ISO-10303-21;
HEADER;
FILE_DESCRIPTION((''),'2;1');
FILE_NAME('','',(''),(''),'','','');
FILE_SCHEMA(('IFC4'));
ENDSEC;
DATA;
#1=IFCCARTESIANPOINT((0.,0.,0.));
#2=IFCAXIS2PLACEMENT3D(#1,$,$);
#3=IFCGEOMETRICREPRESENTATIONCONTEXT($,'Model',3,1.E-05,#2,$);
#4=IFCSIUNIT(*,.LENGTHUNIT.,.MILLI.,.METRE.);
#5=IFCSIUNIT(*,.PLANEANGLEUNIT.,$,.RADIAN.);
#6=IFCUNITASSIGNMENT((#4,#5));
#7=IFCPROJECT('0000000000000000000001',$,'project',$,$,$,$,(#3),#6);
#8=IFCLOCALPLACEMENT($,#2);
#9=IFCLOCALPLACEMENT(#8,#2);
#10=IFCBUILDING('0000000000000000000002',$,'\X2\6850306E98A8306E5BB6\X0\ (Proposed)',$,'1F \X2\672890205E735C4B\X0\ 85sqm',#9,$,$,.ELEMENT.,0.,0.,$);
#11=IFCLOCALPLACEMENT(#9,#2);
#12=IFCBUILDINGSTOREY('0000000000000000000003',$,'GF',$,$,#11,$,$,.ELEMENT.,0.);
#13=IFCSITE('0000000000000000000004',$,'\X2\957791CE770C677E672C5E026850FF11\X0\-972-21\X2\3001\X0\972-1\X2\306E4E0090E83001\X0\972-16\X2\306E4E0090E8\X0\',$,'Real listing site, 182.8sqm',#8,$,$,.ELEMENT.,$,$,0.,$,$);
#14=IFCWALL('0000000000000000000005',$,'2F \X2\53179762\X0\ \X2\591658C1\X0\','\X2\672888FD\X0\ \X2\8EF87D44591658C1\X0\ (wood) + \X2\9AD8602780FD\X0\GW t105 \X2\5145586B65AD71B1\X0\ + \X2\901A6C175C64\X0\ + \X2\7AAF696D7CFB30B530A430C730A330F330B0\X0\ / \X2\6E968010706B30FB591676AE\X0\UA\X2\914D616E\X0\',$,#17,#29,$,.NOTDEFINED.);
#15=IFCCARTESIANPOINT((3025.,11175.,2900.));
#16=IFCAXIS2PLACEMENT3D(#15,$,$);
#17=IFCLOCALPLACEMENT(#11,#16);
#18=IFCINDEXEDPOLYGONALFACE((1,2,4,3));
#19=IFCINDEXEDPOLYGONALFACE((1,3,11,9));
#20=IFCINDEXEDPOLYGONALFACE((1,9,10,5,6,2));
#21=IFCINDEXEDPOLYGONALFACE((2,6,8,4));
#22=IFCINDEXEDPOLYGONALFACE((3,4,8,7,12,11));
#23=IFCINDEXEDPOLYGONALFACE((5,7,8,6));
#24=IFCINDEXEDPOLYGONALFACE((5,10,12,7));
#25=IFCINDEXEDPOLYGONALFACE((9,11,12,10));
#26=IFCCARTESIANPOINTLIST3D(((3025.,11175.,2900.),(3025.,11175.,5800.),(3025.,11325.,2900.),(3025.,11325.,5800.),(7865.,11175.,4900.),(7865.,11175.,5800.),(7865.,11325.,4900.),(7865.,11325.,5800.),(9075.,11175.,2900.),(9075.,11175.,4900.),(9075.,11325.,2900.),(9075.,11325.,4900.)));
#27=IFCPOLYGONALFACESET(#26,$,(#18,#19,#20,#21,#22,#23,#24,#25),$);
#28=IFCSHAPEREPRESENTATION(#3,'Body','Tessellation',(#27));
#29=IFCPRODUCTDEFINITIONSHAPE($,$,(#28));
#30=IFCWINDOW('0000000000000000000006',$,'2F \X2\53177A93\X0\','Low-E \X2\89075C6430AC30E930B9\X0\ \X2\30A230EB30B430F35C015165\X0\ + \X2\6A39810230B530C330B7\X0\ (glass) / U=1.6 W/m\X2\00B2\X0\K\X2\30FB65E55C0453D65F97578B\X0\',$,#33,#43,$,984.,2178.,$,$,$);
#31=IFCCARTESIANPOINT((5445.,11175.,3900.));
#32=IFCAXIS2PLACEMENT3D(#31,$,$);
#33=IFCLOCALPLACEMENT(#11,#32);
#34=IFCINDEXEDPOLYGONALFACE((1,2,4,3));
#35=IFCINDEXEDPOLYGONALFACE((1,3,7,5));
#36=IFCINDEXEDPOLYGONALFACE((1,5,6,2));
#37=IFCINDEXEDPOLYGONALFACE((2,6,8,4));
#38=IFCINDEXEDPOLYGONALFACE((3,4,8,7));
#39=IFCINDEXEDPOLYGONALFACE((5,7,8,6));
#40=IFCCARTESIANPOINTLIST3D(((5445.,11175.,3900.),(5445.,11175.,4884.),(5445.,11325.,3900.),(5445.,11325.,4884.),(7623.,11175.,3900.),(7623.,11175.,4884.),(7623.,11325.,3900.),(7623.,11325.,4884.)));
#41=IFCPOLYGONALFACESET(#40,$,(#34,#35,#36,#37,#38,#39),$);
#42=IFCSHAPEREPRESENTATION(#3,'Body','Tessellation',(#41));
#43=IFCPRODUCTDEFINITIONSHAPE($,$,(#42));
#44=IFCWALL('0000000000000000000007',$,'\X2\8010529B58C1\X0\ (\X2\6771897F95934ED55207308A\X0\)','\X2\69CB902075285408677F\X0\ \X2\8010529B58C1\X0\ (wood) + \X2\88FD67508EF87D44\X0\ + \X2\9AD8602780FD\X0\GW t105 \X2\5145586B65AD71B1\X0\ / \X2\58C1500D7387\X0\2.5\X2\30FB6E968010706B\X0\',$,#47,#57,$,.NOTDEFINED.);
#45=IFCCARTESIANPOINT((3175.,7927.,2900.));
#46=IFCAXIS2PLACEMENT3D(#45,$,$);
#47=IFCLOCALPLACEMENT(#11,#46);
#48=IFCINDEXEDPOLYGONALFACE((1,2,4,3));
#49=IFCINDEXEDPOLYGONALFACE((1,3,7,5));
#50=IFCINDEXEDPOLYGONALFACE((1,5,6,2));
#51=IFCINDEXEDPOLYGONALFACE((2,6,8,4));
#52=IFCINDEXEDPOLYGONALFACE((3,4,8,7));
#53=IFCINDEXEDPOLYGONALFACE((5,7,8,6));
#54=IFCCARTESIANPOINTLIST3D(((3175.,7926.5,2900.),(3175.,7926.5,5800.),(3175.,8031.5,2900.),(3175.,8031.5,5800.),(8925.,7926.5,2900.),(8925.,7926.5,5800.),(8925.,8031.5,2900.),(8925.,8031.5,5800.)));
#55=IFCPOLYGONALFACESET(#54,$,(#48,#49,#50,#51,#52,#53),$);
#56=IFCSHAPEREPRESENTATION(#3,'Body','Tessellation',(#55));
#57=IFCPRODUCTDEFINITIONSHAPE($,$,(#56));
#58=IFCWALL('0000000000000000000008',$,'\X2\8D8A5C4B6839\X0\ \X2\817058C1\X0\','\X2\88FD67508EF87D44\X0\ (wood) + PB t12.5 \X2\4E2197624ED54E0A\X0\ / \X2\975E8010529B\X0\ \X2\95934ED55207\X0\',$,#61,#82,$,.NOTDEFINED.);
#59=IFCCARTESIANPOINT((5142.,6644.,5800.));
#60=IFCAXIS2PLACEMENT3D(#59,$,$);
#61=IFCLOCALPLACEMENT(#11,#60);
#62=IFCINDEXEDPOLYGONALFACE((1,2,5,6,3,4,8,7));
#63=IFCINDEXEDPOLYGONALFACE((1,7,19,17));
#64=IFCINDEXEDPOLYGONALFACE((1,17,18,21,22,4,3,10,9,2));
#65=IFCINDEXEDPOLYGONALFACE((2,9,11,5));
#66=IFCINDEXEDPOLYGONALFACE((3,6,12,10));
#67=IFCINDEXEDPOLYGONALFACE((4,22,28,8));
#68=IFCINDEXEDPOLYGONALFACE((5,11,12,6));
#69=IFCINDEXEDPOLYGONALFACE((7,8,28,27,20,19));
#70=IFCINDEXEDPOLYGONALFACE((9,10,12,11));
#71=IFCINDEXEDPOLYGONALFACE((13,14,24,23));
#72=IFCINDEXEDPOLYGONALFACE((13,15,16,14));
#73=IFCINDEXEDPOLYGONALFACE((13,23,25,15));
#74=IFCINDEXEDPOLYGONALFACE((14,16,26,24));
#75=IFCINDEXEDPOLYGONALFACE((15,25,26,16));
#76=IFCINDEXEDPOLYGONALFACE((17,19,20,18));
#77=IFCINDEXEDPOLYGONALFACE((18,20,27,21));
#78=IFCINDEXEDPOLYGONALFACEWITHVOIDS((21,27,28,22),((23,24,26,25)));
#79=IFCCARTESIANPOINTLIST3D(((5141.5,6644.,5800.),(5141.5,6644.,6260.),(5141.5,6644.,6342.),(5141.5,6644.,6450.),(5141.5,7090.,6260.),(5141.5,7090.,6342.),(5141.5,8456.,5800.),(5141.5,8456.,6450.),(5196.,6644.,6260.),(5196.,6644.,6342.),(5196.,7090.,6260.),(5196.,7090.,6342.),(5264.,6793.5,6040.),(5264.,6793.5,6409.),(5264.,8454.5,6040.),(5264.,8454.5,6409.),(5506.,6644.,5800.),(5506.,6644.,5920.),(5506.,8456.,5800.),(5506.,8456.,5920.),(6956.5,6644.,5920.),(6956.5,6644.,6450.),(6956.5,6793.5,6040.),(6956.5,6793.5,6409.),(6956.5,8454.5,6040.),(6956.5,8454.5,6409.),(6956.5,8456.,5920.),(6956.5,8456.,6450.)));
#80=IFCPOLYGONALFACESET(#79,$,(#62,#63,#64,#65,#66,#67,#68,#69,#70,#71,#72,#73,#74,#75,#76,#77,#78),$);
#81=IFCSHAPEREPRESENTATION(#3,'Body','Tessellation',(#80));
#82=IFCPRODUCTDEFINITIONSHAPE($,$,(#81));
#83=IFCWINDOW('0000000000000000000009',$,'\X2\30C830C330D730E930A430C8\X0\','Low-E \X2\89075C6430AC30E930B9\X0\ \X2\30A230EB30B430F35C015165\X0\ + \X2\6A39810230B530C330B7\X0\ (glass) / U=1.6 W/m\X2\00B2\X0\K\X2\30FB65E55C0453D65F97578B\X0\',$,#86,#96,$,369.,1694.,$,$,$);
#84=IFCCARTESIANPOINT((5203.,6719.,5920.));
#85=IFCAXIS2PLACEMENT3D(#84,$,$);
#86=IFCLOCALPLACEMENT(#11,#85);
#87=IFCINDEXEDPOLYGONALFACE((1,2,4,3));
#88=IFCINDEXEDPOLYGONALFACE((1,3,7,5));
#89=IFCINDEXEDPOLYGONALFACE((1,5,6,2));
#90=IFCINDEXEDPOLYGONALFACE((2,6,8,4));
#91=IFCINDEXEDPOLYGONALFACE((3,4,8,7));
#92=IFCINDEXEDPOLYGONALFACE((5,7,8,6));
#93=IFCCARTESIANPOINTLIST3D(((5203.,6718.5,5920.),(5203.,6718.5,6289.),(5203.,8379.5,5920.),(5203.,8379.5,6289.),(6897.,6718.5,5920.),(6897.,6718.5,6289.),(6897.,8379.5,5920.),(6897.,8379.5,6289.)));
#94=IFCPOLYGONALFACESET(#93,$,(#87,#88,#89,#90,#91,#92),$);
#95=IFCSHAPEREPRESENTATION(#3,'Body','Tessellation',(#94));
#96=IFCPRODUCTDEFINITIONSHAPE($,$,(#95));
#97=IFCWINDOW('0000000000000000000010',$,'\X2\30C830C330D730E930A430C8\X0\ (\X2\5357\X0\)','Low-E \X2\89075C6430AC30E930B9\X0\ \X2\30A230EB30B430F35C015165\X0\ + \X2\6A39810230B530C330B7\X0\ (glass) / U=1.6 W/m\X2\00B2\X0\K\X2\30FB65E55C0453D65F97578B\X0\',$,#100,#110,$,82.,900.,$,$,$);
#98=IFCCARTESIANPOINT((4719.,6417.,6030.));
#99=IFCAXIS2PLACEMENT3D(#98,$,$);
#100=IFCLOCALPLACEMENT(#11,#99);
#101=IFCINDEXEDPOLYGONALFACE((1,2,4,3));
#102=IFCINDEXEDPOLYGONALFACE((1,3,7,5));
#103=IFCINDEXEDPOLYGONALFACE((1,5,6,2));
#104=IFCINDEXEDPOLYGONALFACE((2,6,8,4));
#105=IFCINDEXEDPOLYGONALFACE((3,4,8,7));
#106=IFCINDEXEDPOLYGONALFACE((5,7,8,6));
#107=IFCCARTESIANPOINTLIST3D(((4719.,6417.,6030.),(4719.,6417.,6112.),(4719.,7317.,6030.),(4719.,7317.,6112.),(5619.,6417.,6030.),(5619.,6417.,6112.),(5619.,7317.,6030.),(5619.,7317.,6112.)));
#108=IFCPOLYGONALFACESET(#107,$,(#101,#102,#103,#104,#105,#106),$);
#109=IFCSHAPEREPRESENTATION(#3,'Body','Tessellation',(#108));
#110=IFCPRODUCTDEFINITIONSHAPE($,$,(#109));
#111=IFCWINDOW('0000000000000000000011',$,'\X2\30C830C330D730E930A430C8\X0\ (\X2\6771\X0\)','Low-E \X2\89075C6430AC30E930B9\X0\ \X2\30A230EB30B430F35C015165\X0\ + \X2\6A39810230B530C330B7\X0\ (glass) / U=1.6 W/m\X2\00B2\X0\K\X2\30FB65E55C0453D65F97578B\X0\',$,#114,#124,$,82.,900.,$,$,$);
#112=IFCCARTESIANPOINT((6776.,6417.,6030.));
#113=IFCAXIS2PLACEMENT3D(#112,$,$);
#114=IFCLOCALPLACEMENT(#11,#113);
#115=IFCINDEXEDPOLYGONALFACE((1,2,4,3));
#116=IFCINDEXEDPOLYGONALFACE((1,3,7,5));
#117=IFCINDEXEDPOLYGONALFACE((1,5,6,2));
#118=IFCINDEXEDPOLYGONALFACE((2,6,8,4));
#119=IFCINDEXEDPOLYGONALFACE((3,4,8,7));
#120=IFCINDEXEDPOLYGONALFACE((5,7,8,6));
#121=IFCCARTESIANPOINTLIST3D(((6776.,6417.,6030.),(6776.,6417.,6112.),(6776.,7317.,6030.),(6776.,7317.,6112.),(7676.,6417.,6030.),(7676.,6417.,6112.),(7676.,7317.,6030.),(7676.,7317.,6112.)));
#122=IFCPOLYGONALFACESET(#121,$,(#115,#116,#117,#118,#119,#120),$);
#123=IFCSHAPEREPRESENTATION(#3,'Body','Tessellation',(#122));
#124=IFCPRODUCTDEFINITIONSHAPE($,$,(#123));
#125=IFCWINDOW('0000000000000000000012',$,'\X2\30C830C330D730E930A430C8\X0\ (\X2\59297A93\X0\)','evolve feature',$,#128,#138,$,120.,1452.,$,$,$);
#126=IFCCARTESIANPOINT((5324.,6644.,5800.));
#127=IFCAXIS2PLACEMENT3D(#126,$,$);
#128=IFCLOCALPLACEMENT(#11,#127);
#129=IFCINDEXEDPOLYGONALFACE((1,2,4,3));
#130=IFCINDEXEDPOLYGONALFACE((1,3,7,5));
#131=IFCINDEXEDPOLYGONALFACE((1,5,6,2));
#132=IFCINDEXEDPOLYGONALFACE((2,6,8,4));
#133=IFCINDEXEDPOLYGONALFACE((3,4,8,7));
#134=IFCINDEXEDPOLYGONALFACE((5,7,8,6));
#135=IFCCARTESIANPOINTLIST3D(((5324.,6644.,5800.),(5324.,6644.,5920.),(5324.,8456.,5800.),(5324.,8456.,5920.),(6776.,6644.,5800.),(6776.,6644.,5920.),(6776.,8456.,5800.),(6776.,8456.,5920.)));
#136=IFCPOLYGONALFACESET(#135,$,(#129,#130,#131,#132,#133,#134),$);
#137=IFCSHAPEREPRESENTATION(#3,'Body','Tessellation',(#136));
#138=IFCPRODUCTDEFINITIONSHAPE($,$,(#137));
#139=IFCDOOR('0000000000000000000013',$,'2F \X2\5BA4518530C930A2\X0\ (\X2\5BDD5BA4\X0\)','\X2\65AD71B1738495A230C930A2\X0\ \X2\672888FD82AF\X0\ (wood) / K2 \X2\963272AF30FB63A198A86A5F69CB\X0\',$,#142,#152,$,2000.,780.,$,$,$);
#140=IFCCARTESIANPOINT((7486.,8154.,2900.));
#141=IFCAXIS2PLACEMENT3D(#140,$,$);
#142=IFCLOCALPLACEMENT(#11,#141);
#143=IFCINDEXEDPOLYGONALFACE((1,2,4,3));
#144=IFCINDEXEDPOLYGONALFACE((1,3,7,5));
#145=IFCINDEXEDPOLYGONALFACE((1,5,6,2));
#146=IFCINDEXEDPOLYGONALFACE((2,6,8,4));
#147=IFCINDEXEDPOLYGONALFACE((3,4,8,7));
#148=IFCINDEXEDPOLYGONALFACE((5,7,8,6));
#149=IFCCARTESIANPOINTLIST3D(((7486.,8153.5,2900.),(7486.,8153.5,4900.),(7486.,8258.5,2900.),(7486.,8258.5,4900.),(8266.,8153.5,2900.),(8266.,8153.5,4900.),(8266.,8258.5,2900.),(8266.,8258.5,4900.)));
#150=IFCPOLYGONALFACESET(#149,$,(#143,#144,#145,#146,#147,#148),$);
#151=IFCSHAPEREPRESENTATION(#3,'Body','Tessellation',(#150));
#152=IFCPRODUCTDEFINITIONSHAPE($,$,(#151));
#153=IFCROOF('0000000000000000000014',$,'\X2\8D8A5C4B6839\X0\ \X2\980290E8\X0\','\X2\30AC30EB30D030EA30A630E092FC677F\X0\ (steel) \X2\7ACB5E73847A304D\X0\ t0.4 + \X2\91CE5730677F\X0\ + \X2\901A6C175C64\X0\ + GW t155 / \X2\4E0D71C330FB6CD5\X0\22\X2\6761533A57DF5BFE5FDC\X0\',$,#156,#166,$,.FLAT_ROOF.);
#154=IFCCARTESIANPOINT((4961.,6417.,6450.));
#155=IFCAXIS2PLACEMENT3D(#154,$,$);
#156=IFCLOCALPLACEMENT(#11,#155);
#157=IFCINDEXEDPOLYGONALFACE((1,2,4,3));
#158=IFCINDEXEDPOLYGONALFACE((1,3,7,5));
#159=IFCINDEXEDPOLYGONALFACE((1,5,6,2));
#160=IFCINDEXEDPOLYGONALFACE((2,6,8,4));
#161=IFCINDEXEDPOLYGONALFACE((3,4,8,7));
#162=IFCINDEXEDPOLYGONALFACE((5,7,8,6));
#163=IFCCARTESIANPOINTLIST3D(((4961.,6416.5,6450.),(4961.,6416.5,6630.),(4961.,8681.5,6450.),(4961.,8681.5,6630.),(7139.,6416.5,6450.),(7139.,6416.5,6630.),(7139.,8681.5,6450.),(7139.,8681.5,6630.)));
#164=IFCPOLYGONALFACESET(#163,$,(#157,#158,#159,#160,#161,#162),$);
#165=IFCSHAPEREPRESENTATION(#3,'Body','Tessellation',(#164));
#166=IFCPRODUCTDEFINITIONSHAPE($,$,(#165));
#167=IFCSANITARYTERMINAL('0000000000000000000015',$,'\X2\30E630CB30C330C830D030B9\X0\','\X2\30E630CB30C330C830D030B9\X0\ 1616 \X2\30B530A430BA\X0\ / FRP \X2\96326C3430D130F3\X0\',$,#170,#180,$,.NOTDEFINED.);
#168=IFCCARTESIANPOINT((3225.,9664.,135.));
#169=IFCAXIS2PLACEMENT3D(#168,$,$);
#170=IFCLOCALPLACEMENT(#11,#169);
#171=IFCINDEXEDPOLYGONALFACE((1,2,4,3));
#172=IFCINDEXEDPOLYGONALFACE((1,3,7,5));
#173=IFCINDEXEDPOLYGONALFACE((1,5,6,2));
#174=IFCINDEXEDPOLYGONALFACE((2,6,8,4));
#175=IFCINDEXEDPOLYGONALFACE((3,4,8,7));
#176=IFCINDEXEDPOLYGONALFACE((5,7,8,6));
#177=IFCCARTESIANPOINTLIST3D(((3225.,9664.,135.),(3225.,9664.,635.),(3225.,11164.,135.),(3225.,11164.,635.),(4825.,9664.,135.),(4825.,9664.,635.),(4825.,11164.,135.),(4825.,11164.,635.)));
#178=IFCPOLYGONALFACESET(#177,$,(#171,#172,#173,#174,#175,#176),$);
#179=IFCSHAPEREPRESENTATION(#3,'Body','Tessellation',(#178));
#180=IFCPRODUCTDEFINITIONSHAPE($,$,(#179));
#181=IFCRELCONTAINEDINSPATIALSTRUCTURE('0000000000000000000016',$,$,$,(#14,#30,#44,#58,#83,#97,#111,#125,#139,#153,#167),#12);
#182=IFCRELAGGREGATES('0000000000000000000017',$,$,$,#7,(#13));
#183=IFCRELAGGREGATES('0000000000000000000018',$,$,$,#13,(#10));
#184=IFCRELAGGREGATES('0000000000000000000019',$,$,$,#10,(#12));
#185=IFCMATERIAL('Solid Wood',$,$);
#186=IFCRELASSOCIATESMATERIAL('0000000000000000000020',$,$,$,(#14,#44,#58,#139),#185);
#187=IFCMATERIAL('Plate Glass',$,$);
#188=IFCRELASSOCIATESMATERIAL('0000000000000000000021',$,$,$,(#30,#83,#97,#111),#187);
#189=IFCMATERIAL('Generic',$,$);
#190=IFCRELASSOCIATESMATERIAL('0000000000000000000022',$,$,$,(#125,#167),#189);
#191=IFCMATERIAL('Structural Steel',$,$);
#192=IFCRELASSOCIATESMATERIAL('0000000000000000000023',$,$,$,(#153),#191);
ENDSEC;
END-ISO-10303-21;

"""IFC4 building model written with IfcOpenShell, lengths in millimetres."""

from ifc_helpers import new_model, si_unit, frame, frame_2d, origin, place, context, project, spatial, rectangle, extrude, material, element, fill, save


model = new_model("IFC4")

# Units and contexts
model_context = context("Model", 3, precision=1e-05, world=origin())
ifc_project = project(units=[si_unit("LENGTHUNIT", "METRE", prefix="MILLI"), si_unit("PLANEANGLEUNIT", "RADIAN")], contexts=[model_context])

# Site, building, storey
site_placement = place(None, origin())
site = spatial("IfcSite", under=ifc_project, at=site_placement, Name="長野県松本市桐１-972-21、972-1の一部、972-16の一部", ObjectType="Real listing site, 182.8sqm", CompositionType="ELEMENT", RefElevation=0.0)
building_placement = place(site_placement, origin())
building = spatial("IfcBuilding", under=site, at=building_placement, Name="桐の風の家 (Proposed)", ObjectType="1F 木造平屋 85sqm", CompositionType="ELEMENT", ElevationOfRefHeight=0.0, ElevationOfTerrain=0.0)
storey_placement = place(building_placement, origin())
storey = spatial("IfcBuildingStorey", under=building, at=storey_placement, Name="GF", CompositionType="ELEMENT", Elevation=0.0)

# Wall, opening, window
ifc_material_1 = material(Name="Solid Wood")
wall_1_placement = place(storey_placement, frame((3025.0, 11175.0, 2900.0)))
wall_1 = element("IfcWall", 1, at=wall_1_placement, inside=storey, material=ifc_material_1, Name="2F 北面 外壁", Description="木製 軸組外壁 (wood) + 高性能GW t105 充填断熱 + 通気層 + 窯業系サイディング / 準耐火・外皮UA配慮", PredefinedType="NOTDEFINED", context=model_context, shape_type="SweptSolid", body=[
    extrude(rectangle(XDim=6050.0, YDim=150.0, at=frame_2d((3025.0, 75.0))), frame((3025.0, 11175.0, 2900.0)), (0.0, 0.0, 1.0), 2900.0),
])
opening_1_placement = place(storey_placement, frame((5445.0, 11175.0, 3900.0)))
opening_1 = element("IfcOpeningElement", 2, at=opening_1_placement, cuts=wall_1, PredefinedType="NOTDEFINED", context=model_context, shape_type="SweptSolid", body=[
    extrude(rectangle(XDim=2178.0, YDim=150.0, at=frame_2d((1089.0, 75.0))), frame((5445.0, 11175.0, 3900.0)), (0.0, 0.0, 1.0), 984.0),
])
ifc_material_2 = material(Name="Plate Glass")
window_1_placement = place(storey_placement, frame((5445.0, 11175.0, 3900.0)))
window_1 = element("IfcWindow", 3, at=window_1_placement, inside=storey, material=ifc_material_2, Name="2F 北窓", Description="Low-E 複層ガラス アルゴン封入 + 樹脂サッシ (glass) / U=1.6 W/m²K・日射取得型", OverallHeight=984.0, OverallWidth=2178.0, context=model_context, shape_type="SweptSolid", body=[
    extrude(rectangle(XDim=2178.0, YDim=150.0, at=frame_2d((1089.0, 75.0))), frame((5445.0, 11175.0, 3900.0)), (0.0, 0.0, 1.0), 984.0),
])
fill(opening_1, window_1)

# Wall
wall_2_placement = place(storey_placement, frame((3175.0, 7927.0, 2900.0)))
element("IfcWall", 4, at=wall_2_placement, inside=storey, material=ifc_material_1, Name="耐力壁 (東西間仕切り)", Description="構造用合板 耐力壁 (wood) + 製材軸組 + 高性能GW t105 充填断熱 / 壁倍率2.5・準耐火", PredefinedType="NOTDEFINED", context=model_context, shape_type="SweptSolid", body=[
    extrude(rectangle(XDim=5750.0, YDim=105.0, at=frame_2d((2875.0, 52.0))), frame((3175.0, 7927.0, 2900.0)), (0.0, 0.0, 1.0), 2900.0),
])

# Wall, openings, windows
wall_3_placement = place(storey_placement, frame((5142.0, 6644.0, 5800.0)))
wall_3 = element("IfcWall", 5, at=wall_3_placement, inside=storey, material=ifc_material_1, Name="越屋根 腰壁", Description="製材軸組 (wood) + PB t12.5 両面仕上 / 非耐力 間仕切", PredefinedType="NOTDEFINED", context=model_context, shape_type="SweptSolid", body=[
    extrude(rectangle(XDim=1815.0, YDim=1812.0, at=frame_2d((907.0, 906.0))), frame((5142.0, 6644.0, 5800.0)), (0.0, 0.0, 1.0), 650.0),
])
opening_2_placement = place(storey_placement, frame((5203.0, 6719.0, 5920.0)))
opening_2 = element("IfcOpeningElement", 6, at=opening_2_placement, cuts=wall_3, PredefinedType="NOTDEFINED", context=model_context, shape_type="SweptSolid", body=[
    extrude(rectangle(XDim=1694.0, YDim=1661.0, at=frame_2d((847.0, 830.0))), frame((5203.0, 6719.0, 5920.0)), (0.0, 0.0, 1.0), 369.0),
])
opening_3_placement = place(storey_placement, frame((4719.0, 6417.0, 6030.0)))
opening_3 = element("IfcOpeningElement", 7, at=opening_3_placement, cuts=wall_3, PredefinedType="NOTDEFINED", context=model_context, shape_type="SweptSolid", body=[
    extrude(rectangle(XDim=900.0, YDim=900.0, at=frame_2d((450.0, 450.0))), frame((4719.0, 6417.0, 6030.0)), (0.0, 0.0, 1.0), 82.0),
])
opening_4_placement = place(storey_placement, frame((6776.0, 6417.0, 6030.0)))
opening_4 = element("IfcOpeningElement", 8, at=opening_4_placement, cuts=wall_3, PredefinedType="NOTDEFINED", context=model_context, shape_type="SweptSolid", body=[
    extrude(rectangle(XDim=900.0, YDim=900.0, at=frame_2d((450.0, 450.0))), frame((6776.0, 6417.0, 6030.0)), (0.0, 0.0, 1.0), 82.0),
])
opening_5_placement = place(storey_placement, frame((5324.0, 6644.0, 5800.0)))
opening_5 = element("IfcOpeningElement", 9, at=opening_5_placement, cuts=wall_3, PredefinedType="NOTDEFINED", context=model_context, shape_type="SweptSolid", body=[
    extrude(rectangle(XDim=1452.0, YDim=1812.0, at=frame_2d((726.0, 906.0))), frame((5324.0, 6644.0, 5800.0)), (0.0, 0.0, 1.0), 120.0),
])
window_2_placement = place(storey_placement, frame((5203.0, 6719.0, 5920.0)))
window_2 = element("IfcWindow", 10, at=window_2_placement, inside=storey, material=ifc_material_2, Name="トップライト", Description="Low-E 複層ガラス アルゴン封入 + 樹脂サッシ (glass) / U=1.6 W/m²K・日射取得型", OverallHeight=369.0, OverallWidth=1694.0, context=model_context, shape_type="SweptSolid", body=[
    extrude(rectangle(XDim=1694.0, YDim=1661.0, at=frame_2d((847.0, 830.0))), frame((5203.0, 6719.0, 5920.0)), (0.0, 0.0, 1.0), 369.0),
])
fill(opening_2, window_2)
window_3_placement = place(storey_placement, frame((4719.0, 6417.0, 6030.0)))
window_3 = element("IfcWindow", 11, at=window_3_placement, inside=storey, material=ifc_material_2, Name="トップライト (南)", Description="Low-E 複層ガラス アルゴン封入 + 樹脂サッシ (glass) / U=1.6 W/m²K・日射取得型", OverallHeight=82.0, OverallWidth=900.0, context=model_context, shape_type="SweptSolid", body=[
    extrude(rectangle(XDim=900.0, YDim=900.0, at=frame_2d((450.0, 450.0))), frame((4719.0, 6417.0, 6030.0)), (0.0, 0.0, 1.0), 82.0),
])
fill(opening_3, window_3)
window_4_placement = place(storey_placement, frame((6776.0, 6417.0, 6030.0)))
window_4 = element("IfcWindow", 12, at=window_4_placement, inside=storey, material=ifc_material_2, Name="トップライト (東)", Description="Low-E 複層ガラス アルゴン封入 + 樹脂サッシ (glass) / U=1.6 W/m²K・日射取得型", OverallHeight=82.0, OverallWidth=900.0, context=model_context, shape_type="SweptSolid", body=[
    extrude(rectangle(XDim=900.0, YDim=900.0, at=frame_2d((450.0, 450.0))), frame((6776.0, 6417.0, 6030.0)), (0.0, 0.0, 1.0), 82.0),
])
fill(opening_4, window_4)
ifc_material_3 = material(Name="Generic")
window_5_placement = place(storey_placement, frame((5324.0, 6644.0, 5800.0)))
window_5 = element("IfcWindow", 13, at=window_5_placement, inside=storey, material=ifc_material_3, Name="トップライト (天窓)", Description="evolve feature", OverallHeight=120.0, OverallWidth=1452.0, context=model_context, shape_type="SweptSolid", body=[
    extrude(rectangle(XDim=1452.0, YDim=1812.0, at=frame_2d((726.0, 906.0))), frame((5324.0, 6644.0, 5800.0)), (0.0, 0.0, 1.0), 120.0),
])
fill(opening_5, window_5)

# Door
door_placement = place(storey_placement, frame((7486.0, 8154.0, 2900.0)))
element("IfcDoor", 14, at=door_placement, inside=storey, material=ifc_material_1, Name="2F 室内ドア (寝室)", Description="断熱玄関ドア 木製芯 (wood) / K2 防犯・採風機構", OverallHeight=2000.0, OverallWidth=780.0, context=model_context, shape_type="SweptSolid", body=[
    extrude(rectangle(XDim=780.0, YDim=105.0, at=frame_2d((390.0, 52.0))), frame((7486.0, 8154.0, 2900.0)), (0.0, 0.0, 1.0), 2000.0),
])

# Roof
ifc_material_4 = material(Name="Structural Steel")
roof_placement = place(storey_placement, frame((4961.0, 6417.0, 6450.0)))
element("IfcRoof", 15, at=roof_placement, inside=storey, material=ifc_material_4, Name="越屋根 頂部", Description="ガルバリウム鋼板 (steel) 立平葺き t0.4 + 野地板 + 通気層 + GW t155 / 不燃・法22条区域対応", PredefinedType="FLAT_ROOF", context=model_context, shape_type="SweptSolid", body=[
    extrude(rectangle(XDim=2178.0, YDim=2265.0, at=frame_2d((1089.0, 1132.0))), frame((4961.0, 6417.0, 6450.0)), (0.0, 0.0, 1.0), 180.0),
])

# Sanitary terminal
sanitary_terminal_1_placement = place(storey_placement, frame((3225.0, 9664.0, 135.0)))
element("IfcSanitaryTerminal", 16, at=sanitary_terminal_1_placement, inside=storey, material=ifc_material_3, Name="ユニットバス", Description="ユニットバス 1616 サイズ / FRP 防水パン", PredefinedType="NOTDEFINED", context=model_context, shape_type="SweptSolid", body=[
    extrude(rectangle(XDim=1600.0, YDim=1500.0, at=frame_2d((800.0, 750.0))), frame((3225.0, 9664.0, 135.0)), (0.0, 0.0, 1.0), 500.0),
])

save(model, "model.ifc")
